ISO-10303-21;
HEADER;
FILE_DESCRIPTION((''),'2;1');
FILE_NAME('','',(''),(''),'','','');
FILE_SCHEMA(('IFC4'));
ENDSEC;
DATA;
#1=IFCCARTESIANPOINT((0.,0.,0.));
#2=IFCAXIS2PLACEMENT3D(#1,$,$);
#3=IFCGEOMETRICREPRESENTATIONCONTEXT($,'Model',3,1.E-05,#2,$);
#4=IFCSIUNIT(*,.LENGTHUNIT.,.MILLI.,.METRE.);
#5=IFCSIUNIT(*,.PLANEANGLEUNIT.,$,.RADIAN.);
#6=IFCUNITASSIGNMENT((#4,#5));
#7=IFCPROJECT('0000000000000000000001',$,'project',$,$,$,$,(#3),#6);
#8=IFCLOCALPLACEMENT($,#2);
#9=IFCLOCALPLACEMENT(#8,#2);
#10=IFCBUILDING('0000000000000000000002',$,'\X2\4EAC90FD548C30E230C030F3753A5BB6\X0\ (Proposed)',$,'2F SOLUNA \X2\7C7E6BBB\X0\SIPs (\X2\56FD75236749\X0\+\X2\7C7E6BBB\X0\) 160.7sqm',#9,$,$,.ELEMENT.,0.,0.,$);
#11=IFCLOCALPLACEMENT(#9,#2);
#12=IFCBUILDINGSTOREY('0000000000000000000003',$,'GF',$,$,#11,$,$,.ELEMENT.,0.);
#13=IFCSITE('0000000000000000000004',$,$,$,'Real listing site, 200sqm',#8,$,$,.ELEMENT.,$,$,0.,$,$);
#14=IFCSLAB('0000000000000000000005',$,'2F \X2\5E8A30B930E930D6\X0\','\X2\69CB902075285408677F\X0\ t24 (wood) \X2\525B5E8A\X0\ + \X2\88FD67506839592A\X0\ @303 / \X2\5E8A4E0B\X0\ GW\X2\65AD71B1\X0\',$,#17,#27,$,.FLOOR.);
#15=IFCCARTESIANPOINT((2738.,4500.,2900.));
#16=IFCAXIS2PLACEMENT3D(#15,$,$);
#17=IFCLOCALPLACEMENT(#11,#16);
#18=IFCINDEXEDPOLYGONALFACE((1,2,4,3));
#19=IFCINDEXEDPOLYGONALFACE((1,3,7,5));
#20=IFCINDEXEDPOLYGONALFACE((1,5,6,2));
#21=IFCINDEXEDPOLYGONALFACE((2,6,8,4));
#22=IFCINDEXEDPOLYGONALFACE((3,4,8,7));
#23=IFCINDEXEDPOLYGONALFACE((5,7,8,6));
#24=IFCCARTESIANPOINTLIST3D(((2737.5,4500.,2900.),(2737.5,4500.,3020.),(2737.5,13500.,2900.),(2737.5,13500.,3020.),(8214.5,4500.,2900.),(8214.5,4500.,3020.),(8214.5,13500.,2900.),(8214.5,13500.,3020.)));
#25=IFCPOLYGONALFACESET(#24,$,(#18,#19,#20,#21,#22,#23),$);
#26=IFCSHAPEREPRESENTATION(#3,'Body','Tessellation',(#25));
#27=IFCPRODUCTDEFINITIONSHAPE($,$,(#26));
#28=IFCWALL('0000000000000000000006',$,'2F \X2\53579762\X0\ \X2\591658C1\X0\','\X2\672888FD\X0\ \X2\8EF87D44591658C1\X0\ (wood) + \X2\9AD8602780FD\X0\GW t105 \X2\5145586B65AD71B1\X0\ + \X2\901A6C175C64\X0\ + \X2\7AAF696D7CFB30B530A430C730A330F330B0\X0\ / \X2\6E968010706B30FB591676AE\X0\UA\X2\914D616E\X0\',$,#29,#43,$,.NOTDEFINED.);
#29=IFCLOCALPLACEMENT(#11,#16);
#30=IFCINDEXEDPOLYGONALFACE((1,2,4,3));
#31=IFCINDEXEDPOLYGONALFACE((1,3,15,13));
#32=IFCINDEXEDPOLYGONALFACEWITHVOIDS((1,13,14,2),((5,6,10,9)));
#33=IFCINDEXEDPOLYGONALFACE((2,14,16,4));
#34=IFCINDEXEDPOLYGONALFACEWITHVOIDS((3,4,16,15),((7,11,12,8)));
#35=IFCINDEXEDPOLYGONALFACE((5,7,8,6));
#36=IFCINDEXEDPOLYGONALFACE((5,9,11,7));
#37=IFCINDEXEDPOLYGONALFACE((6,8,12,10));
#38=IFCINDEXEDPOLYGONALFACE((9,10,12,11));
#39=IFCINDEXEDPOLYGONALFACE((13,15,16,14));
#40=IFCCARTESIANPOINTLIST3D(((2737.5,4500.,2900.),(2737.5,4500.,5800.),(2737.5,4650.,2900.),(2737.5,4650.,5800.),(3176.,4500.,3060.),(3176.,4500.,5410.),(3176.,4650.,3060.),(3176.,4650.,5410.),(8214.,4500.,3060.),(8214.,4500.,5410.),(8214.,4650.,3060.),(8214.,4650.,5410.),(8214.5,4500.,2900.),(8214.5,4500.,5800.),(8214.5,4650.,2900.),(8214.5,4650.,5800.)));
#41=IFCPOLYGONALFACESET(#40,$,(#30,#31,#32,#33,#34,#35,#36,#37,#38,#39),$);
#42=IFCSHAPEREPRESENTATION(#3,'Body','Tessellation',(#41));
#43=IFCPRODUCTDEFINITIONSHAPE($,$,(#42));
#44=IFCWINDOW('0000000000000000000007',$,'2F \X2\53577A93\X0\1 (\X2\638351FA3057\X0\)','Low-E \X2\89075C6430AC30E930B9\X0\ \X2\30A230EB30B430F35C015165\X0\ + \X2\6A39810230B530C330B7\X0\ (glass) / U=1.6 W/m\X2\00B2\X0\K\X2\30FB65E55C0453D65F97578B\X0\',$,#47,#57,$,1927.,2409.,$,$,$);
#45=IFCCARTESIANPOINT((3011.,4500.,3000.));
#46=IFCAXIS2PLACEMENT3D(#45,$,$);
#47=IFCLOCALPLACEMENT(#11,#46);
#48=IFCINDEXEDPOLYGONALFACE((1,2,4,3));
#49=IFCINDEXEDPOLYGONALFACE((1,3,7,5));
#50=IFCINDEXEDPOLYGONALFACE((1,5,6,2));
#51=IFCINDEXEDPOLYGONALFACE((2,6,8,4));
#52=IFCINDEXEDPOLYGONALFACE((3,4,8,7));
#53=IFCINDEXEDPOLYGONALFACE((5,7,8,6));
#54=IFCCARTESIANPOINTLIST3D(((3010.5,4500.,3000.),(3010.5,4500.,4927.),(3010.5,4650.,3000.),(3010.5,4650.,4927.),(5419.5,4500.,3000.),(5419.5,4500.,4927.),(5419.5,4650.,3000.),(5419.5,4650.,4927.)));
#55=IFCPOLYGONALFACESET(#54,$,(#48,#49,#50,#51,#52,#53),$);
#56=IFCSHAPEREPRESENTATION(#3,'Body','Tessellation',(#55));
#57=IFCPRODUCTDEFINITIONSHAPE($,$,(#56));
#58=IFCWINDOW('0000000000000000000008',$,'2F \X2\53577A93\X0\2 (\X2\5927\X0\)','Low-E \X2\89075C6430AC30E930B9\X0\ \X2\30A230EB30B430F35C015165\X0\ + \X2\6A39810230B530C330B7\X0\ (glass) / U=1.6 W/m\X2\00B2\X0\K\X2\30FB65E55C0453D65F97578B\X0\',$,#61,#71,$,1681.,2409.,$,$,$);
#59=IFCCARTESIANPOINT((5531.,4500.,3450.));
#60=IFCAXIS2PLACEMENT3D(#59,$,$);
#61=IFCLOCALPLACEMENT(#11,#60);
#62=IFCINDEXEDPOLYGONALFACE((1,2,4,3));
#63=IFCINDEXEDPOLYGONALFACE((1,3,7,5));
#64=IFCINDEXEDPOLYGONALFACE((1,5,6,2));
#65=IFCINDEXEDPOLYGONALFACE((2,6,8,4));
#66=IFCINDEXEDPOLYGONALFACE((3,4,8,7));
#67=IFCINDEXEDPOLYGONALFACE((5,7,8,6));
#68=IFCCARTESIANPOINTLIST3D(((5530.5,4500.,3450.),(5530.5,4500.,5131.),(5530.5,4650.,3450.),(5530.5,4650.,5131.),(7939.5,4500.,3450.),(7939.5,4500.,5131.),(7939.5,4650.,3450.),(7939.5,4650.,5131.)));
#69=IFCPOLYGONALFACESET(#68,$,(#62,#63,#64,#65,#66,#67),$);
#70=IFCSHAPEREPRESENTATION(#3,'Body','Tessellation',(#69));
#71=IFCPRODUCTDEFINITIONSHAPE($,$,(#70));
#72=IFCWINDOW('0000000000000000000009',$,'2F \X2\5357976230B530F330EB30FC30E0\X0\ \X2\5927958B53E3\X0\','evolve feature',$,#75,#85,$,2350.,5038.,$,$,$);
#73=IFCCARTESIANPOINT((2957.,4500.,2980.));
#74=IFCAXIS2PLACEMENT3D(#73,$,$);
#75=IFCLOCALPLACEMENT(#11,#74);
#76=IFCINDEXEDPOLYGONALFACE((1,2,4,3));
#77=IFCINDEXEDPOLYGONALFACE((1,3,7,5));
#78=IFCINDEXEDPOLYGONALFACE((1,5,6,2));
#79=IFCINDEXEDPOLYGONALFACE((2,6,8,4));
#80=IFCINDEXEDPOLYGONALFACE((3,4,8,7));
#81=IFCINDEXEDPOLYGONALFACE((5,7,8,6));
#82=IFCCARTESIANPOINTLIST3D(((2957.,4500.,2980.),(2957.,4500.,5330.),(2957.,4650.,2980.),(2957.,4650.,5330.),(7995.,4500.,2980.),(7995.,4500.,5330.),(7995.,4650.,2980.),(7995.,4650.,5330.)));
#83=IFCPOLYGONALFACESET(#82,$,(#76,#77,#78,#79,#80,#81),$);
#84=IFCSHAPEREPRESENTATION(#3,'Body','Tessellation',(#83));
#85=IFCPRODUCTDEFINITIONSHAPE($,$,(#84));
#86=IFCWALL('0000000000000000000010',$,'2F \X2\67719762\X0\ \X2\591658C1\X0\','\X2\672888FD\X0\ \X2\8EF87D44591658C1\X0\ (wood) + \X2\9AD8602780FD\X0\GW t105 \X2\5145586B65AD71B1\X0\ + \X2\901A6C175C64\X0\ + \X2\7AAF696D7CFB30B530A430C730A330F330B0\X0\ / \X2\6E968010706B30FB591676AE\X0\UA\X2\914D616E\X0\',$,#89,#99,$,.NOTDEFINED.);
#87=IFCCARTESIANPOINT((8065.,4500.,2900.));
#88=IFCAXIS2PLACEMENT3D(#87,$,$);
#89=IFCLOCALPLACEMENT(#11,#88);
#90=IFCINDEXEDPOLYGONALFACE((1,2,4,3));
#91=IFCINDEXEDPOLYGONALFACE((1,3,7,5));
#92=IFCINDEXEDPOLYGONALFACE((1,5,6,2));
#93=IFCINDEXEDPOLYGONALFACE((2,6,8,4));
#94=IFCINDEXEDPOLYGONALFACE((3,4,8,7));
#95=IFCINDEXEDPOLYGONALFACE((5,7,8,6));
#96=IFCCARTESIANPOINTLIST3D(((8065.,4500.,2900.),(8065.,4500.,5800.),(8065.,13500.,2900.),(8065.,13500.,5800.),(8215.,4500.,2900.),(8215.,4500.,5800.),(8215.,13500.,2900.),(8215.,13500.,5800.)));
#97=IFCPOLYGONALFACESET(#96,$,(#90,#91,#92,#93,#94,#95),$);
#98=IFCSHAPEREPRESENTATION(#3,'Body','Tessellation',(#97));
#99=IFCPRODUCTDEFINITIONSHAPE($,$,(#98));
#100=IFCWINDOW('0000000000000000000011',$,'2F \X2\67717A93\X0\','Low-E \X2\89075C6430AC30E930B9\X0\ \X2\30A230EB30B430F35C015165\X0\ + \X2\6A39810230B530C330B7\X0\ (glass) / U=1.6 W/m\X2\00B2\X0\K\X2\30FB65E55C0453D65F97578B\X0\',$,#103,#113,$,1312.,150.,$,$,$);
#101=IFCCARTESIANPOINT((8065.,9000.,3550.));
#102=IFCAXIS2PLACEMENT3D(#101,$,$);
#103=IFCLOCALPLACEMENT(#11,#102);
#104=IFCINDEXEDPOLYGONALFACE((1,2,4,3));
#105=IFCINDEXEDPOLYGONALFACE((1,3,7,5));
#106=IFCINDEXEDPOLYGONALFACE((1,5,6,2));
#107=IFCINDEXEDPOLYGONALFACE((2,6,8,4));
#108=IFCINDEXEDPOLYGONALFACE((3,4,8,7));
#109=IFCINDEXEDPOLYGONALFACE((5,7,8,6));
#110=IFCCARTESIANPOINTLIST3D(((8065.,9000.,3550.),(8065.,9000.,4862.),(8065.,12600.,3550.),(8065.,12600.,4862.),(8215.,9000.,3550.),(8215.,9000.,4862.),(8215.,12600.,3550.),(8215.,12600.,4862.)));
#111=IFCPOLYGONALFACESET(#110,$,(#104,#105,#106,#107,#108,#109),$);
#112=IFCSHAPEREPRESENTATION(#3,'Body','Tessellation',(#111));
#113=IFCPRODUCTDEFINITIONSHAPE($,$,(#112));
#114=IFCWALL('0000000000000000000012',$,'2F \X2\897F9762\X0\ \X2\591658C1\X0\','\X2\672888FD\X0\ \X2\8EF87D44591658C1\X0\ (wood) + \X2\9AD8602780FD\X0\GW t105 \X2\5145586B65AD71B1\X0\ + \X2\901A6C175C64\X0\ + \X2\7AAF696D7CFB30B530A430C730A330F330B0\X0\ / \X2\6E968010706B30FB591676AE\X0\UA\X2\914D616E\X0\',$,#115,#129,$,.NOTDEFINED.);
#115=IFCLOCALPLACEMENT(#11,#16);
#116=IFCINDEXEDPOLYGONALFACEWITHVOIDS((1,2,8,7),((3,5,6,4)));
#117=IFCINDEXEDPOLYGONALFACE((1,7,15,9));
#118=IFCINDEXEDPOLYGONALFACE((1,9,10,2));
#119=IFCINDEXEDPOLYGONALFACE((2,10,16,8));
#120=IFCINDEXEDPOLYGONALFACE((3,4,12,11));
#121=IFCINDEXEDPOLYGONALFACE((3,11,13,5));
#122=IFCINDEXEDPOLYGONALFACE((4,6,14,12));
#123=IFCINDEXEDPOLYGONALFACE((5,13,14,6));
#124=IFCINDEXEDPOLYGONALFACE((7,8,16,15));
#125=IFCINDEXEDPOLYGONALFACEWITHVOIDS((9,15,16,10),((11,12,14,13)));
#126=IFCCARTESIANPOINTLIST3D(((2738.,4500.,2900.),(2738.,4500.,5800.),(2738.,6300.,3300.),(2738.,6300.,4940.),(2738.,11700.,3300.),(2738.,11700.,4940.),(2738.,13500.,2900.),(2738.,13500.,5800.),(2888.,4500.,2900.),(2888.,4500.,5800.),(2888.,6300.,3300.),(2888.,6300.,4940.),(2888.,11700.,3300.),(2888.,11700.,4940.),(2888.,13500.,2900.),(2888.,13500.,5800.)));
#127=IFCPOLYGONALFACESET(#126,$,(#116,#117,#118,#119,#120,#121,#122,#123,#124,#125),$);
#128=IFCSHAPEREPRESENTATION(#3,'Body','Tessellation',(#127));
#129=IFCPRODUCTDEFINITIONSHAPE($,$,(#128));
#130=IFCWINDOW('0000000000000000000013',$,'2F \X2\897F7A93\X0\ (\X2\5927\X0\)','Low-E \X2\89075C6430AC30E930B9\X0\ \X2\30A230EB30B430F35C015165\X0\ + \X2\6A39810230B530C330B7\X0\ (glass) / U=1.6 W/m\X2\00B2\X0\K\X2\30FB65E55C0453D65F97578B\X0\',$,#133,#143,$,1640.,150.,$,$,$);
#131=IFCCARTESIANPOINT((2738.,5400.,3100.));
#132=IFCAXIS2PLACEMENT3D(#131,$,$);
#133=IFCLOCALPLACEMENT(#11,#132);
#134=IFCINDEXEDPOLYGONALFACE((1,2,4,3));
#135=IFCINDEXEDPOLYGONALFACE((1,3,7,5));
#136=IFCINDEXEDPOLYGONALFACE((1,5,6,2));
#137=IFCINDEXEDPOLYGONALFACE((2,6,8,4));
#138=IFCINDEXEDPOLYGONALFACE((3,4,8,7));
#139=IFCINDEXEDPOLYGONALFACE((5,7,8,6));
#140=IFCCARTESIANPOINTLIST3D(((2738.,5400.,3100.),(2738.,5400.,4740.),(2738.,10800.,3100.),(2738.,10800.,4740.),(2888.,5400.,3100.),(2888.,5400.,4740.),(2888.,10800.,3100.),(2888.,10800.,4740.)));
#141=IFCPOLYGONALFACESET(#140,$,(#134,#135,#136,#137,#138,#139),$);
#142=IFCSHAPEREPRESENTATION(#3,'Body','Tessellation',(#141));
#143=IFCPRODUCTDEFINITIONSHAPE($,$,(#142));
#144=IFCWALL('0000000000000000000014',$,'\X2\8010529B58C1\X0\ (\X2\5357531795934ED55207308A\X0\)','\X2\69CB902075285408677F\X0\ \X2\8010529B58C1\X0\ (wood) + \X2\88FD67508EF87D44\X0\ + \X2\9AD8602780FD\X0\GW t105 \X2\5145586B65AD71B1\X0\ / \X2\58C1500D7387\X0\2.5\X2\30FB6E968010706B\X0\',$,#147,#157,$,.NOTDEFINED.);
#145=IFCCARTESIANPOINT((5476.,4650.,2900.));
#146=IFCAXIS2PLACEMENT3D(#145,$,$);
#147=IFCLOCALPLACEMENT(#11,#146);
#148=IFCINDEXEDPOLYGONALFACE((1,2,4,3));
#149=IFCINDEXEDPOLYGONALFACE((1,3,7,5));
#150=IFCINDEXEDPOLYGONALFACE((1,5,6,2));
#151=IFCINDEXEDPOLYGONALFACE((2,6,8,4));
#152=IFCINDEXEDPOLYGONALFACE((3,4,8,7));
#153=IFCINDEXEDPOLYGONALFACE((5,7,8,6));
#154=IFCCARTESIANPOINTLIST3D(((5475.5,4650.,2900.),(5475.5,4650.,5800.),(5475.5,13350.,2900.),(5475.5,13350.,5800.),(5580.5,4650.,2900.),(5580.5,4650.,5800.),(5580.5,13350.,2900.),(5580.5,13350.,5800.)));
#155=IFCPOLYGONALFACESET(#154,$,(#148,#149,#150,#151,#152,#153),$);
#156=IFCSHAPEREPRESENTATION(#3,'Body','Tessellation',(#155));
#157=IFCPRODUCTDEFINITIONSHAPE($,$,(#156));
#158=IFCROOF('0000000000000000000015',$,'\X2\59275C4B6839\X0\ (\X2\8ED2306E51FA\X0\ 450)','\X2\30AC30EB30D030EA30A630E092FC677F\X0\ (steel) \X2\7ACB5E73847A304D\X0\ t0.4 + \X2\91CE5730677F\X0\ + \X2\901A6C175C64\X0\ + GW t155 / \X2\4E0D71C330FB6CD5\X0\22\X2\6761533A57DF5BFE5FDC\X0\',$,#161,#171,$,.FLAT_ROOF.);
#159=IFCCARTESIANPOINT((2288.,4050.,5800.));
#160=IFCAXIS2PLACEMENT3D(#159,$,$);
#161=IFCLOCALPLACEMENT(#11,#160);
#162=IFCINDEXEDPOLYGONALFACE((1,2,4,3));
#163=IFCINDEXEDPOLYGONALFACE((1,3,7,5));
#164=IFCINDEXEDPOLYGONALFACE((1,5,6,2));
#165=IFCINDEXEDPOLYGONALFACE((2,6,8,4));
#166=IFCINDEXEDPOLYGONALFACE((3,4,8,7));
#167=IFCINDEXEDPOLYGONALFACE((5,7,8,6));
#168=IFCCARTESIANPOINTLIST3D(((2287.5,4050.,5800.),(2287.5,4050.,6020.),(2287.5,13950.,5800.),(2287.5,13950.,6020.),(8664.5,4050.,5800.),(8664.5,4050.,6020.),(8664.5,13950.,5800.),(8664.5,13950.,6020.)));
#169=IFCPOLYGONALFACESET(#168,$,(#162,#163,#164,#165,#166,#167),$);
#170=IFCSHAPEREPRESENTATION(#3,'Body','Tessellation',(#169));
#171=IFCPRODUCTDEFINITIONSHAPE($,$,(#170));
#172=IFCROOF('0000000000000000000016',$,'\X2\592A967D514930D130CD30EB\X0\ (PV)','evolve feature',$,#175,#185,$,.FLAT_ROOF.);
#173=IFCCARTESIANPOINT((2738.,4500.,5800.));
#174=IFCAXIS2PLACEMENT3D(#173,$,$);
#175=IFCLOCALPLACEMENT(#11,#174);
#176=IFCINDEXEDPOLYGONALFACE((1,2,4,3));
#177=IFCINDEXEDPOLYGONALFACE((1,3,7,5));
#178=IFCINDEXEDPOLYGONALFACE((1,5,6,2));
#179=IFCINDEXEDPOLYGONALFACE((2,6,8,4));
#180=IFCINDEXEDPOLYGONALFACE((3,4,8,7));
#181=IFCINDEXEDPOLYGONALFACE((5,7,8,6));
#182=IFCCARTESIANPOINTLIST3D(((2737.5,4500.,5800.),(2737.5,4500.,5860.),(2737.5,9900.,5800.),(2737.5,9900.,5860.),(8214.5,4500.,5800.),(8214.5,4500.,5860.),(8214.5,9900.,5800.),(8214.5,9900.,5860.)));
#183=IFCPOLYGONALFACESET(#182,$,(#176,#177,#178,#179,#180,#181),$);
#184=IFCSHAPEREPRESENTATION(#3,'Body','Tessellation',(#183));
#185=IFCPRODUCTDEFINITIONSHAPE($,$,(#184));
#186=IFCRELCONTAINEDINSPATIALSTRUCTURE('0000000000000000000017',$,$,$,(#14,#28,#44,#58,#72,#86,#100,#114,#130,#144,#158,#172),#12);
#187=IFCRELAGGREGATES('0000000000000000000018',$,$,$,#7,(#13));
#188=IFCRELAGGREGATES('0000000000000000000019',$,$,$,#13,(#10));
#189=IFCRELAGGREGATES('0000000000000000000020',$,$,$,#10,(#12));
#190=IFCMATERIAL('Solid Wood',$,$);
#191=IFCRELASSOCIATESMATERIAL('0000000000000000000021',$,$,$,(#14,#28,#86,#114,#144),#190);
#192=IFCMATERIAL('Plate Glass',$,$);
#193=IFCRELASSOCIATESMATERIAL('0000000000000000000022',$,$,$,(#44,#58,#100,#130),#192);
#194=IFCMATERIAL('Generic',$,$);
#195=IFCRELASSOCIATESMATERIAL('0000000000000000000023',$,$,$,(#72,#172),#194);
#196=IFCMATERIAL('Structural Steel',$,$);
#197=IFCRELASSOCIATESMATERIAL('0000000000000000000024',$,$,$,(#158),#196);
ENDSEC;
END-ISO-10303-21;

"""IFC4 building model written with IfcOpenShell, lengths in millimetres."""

from ifc_helpers import new_model, si_unit, frame, frame_2d, origin, place, context, project, spatial, rectangle, extrude, material, element, fill, save


model = new_model("IFC4")

# Units and contexts
model_context = context("Model", 3, precision=1e-05, world=origin())
ifc_project = project(units=[si_unit("LENGTHUNIT", "METRE", prefix="MILLI"), si_unit("PLANEANGLEUNIT", "RADIAN")], contexts=[model_context])

# Site, building, storey
site_placement = place(None, origin())
site = spatial("IfcSite", under=ifc_project, at=site_placement, ObjectType="Real listing site, 200sqm", CompositionType="ELEMENT", RefElevation=0.0)
building_placement = place(site_placement, origin())
building = spatial("IfcBuilding", under=site, at=building_placement, Name="京都和モダン町家 (Proposed)", ObjectType="2F SOLUNA 籾殻SIPs (国産杉+籾殻) 160.7sqm", CompositionType="ELEMENT", ElevationOfRefHeight=0.0, ElevationOfTerrain=0.0)
storey_placement = place(building_placement, origin())
storey = spatial("IfcBuildingStorey", under=building, at=storey_placement, Name="GF", CompositionType="ELEMENT", Elevation=0.0)

# Slab
ifc_material_1 = material(Name="Solid Wood")
slab_placement = place(storey_placement, frame((2738.0, 4500.0, 2900.0)))
element("IfcSlab", 1, at=slab_placement, inside=storey, material=ifc_material_1, Name="2F 床スラブ", Description="構造用合板 t24 (wood) 剛床 + 製材根太 @303 / 床下 GW断熱", PredefinedType="FLOOR", context=model_context, shape_type="SweptSolid", body=[
    extrude(rectangle(XDim=5477.0, YDim=9000.0, at=frame_2d((2738.0, 4500.0))), frame((2738.0, 4500.0, 2900.0)), (0.0, 0.0, 1.0), 120.0),
])

# Wall, openings, windows
wall_1_placement = place(storey_placement, frame((2738.0, 4500.0, 2900.0)))
wall_1 = element("IfcWall", 2, at=wall_1_placement, inside=storey, material=ifc_material_1, Name="2F 南面 外壁", Description="木製 軸組外壁 (wood) + 高性能GW t105 充填断熱 + 通気層 + 窯業系サイディング / 準耐火・外皮UA配慮", PredefinedType="NOTDEFINED", context=model_context, shape_type="SweptSolid", body=[
    extrude(rectangle(XDim=5477.0, YDim=150.0, at=frame_2d((2738.0, 75.0))), frame((2738.0, 4500.0, 2900.0)), (0.0, 0.0, 1.0), 2900.0),
])
opening_1_placement = place(storey_placement, frame((3011.0, 4500.0, 3000.0)))
opening_1 = element("IfcOpeningElement", 3, at=opening_1_placement, cuts=wall_1, PredefinedType="NOTDEFINED", context=model_context, shape_type="SweptSolid", body=[
    extrude(rectangle(XDim=2409.0, YDim=150.0, at=frame_2d((1204.0, 75.0))), frame((3011.0, 4500.0, 3000.0)), (0.0, 0.0, 1.0), 1927.0),
])
opening_2_placement = place(storey_placement, frame((5531.0, 4500.0, 3450.0)))
opening_2 = element("IfcOpeningElement", 4, at=opening_2_placement, cuts=wall_1, PredefinedType="NOTDEFINED", context=model_context, shape_type="SweptSolid", body=[
    extrude(rectangle(XDim=2409.0, YDim=150.0, at=frame_2d((1204.0, 75.0))), frame((5531.0, 4500.0, 3450.0)), (0.0, 0.0, 1.0), 1681.0),
])
opening_3_placement = place(storey_placement, frame((2957.0, 4500.0, 2980.0)))
opening_3 = element("IfcOpeningElement", 5, at=opening_3_placement, cuts=wall_1, PredefinedType="NOTDEFINED", context=model_context, shape_type="SweptSolid", body=[
    extrude(rectangle(XDim=5038.0, YDim=150.0, at=frame_2d((2519.0, 75.0))), frame((2957.0, 4500.0, 2980.0)), (0.0, 0.0, 1.0), 2350.0),
])
ifc_material_2 = material(Name="Plate Glass")
window_1_placement = place(storey_placement, frame((3011.0, 4500.0, 3000.0)))
window_1 = element("IfcWindow", 6, at=window_1_placement, inside=storey, material=ifc_material_2, Name="2F 南窓1 (掃出し)", Description="Low-E 複層ガラス アルゴン封入 + 樹脂サッシ (glass) / U=1.6 W/m²K・日射取得型", OverallHeight=1927.0, OverallWidth=2409.0, context=model_context, shape_type="SweptSolid", body=[
    extrude(rectangle(XDim=2409.0, YDim=150.0, at=frame_2d((1204.0, 75.0))), frame((3011.0, 4500.0, 3000.0)), (0.0, 0.0, 1.0), 1927.0),
])
fill(opening_1, window_1)
window_2_placement = place(storey_placement, frame((5531.0, 4500.0, 3450.0)))
window_2 = element("IfcWindow", 7, at=window_2_placement, inside=storey, material=ifc_material_2, Name="2F 南窓2 (大)", Description="Low-E 複層ガラス アルゴン封入 + 樹脂サッシ (glass) / U=1.6 W/m²K・日射取得型", OverallHeight=1681.0, OverallWidth=2409.0, context=model_context, shape_type="SweptSolid", body=[
    extrude(rectangle(XDim=2409.0, YDim=150.0, at=frame_2d((1204.0, 75.0))), frame((5531.0, 4500.0, 3450.0)), (0.0, 0.0, 1.0), 1681.0),
])
fill(opening_2, window_2)
ifc_material_3 = material(Name="Generic")
window_3_placement = place(storey_placement, frame((2957.0, 4500.0, 2980.0)))
window_3 = element("IfcWindow", 8, at=window_3_placement, inside=storey, material=ifc_material_3, Name="2F 南面サンルーム 大開口", Description="evolve feature", OverallHeight=2350.0, OverallWidth=5038.0, context=model_context, shape_type="SweptSolid", body=[
    extrude(rectangle(XDim=5038.0, YDim=150.0, at=frame_2d((2519.0, 75.0))), frame((2957.0, 4500.0, 2980.0)), (0.0, 0.0, 1.0), 2350.0),
])
fill(opening_3, window_3)

# Walls, openings, windows
wall_2_placement = place(storey_placement, frame((8065.0, 4500.0, 2900.0)))
wall_2 = element("IfcWall", 9, at=wall_2_placement, inside=storey, material=ifc_material_1, Name="2F 東面 外壁", Description="木製 軸組外壁 (wood) + 高性能GW t105 充填断熱 + 通気層 + 窯業系サイディング / 準耐火・外皮UA配慮", PredefinedType="NOTDEFINED", context=model_context, shape_type="SweptSolid", body=[
    extrude(rectangle(XDim=150.0, YDim=9000.0, at=frame_2d((75.0, 4500.0))), frame((8065.0, 4500.0, 2900.0)), (0.0, 0.0, 1.0), 2900.0),
])
opening_4_placement = place(storey_placement, frame((8065.0, 9000.0, 3550.0)))
opening_4 = element("IfcOpeningElement", 10, at=opening_4_placement, cuts=wall_2, PredefinedType="NOTDEFINED", context=model_context, shape_type="SweptSolid", body=[
    extrude(rectangle(XDim=150.0, YDim=3600.0, at=frame_2d((75.0, 1800.0))), frame((8065.0, 9000.0, 3550.0)), (0.0, 0.0, 1.0), 1312.0),
])
window_4_placement = place(storey_placement, frame((8065.0, 9000.0, 3550.0)))
window_4 = element("IfcWindow", 11, at=window_4_placement, inside=storey, material=ifc_material_2, Name="2F 東窓", Description="Low-E 複層ガラス アルゴン封入 + 樹脂サッシ (glass) / U=1.6 W/m²K・日射取得型", OverallHeight=1312.0, OverallWidth=150.0, context=model_context, shape_type="SweptSolid", body=[
    extrude(rectangle(XDim=150.0, YDim=3600.0, at=frame_2d((75.0, 1800.0))), frame((8065.0, 9000.0, 3550.0)), (0.0, 0.0, 1.0), 1312.0),
])
fill(opening_4, window_4)
wall_3_placement = place(storey_placement, frame((2738.0, 4500.0, 2900.0)))
wall_3 = element("IfcWall", 12, at=wall_3_placement, inside=storey, material=ifc_material_1, Name="2F 西面 外壁", Description="木製 軸組外壁 (wood) + 高性能GW t105 充填断熱 + 通気層 + 窯業系サイディング / 準耐火・外皮UA配慮", PredefinedType="NOTDEFINED", context=model_context, shape_type="SweptSolid", body=[
    extrude(rectangle(XDim=150.0, YDim=9000.0, at=frame_2d((75.0, 4500.0))), frame((2738.0, 4500.0, 2900.0)), (0.0, 0.0, 1.0), 2900.0),
])
opening_5_placement = place(storey_placement, frame((2738.0, 5400.0, 3100.0)))
opening_5 = element("IfcOpeningElement", 13, at=opening_5_placement, cuts=wall_3, PredefinedType="NOTDEFINED", context=model_context, shape_type="SweptSolid", body=[
    extrude(rectangle(XDim=150.0, YDim=5400.0, at=frame_2d((75.0, 2700.0))), frame((2738.0, 5400.0, 3100.0)), (0.0, 0.0, 1.0), 1640.0),
])
window_5_placement = place(storey_placement, frame((2738.0, 5400.0, 3100.0)))
window_5 = element("IfcWindow", 14, at=window_5_placement, inside=storey, material=ifc_material_2, Name="2F 西窓 (大)", Description="Low-E 複層ガラス アルゴン封入 + 樹脂サッシ (glass) / U=1.6 W/m²K・日射取得型", OverallHeight=1640.0, OverallWidth=150.0, context=model_context, shape_type="SweptSolid", body=[
    extrude(rectangle(XDim=150.0, YDim=5400.0, at=frame_2d((75.0, 2700.0))), frame((2738.0, 5400.0, 3100.0)), (0.0, 0.0, 1.0), 1640.0),
])
fill(opening_5, window_5)

# Wall
wall_4_placement = place(storey_placement, frame((5476.0, 4650.0, 2900.0)))
element("IfcWall", 15, at=wall_4_placement, inside=storey, material=ifc_material_1, Name="耐力壁 (南北間仕切り)", Description="構造用合板 耐力壁 (wood) + 製材軸組 + 高性能GW t105 充填断熱 / 壁倍率2.5・準耐火", PredefinedType="NOTDEFINED", context=model_context, shape_type="SweptSolid", body=[
    extrude(rectangle(XDim=105.0, YDim=8700.0, at=frame_2d((52.0, 4350.0))), frame((5476.0, 4650.0, 2900.0)), (0.0, 0.0, 1.0), 2900.0),
])

# Roofs
ifc_material_4 = material(Name="Structural Steel")
roof_1_placement = place(storey_placement, frame((2288.0, 4050.0, 5800.0)))
element("IfcRoof", 16, at=roof_1_placement, inside=storey, material=ifc_material_4, Name="大屋根 (軒の出 450)", Description="ガルバリウム鋼板 (steel) 立平葺き t0.4 + 野地板 + 通気層 + GW t155 / 不燃・法22条区域対応", PredefinedType="FLAT_ROOF", context=model_context, shape_type="SweptSolid", body=[
    extrude(rectangle(XDim=6377.0, YDim=9900.0, at=frame_2d((3188.0, 4950.0))), frame((2288.0, 4050.0, 5800.0)), (0.0, 0.0, 1.0), 220.0),
])
roof_2_placement = place(storey_placement, frame((2738.0, 4500.0, 5800.0)))
element("IfcRoof", 17, at=roof_2_placement, inside=storey, material=ifc_material_3, Name="太陽光パネル (PV)", Description="evolve feature", PredefinedType="FLAT_ROOF", context=model_context, shape_type="SweptSolid", body=[
    extrude(rectangle(XDim=5477.0, YDim=5400.0, at=frame_2d((2738.0, 2700.0))), frame((2738.0, 4500.0, 5800.0)), (0.0, 0.0, 1.0), 60.0),
])

save(model, "model.ifc")
